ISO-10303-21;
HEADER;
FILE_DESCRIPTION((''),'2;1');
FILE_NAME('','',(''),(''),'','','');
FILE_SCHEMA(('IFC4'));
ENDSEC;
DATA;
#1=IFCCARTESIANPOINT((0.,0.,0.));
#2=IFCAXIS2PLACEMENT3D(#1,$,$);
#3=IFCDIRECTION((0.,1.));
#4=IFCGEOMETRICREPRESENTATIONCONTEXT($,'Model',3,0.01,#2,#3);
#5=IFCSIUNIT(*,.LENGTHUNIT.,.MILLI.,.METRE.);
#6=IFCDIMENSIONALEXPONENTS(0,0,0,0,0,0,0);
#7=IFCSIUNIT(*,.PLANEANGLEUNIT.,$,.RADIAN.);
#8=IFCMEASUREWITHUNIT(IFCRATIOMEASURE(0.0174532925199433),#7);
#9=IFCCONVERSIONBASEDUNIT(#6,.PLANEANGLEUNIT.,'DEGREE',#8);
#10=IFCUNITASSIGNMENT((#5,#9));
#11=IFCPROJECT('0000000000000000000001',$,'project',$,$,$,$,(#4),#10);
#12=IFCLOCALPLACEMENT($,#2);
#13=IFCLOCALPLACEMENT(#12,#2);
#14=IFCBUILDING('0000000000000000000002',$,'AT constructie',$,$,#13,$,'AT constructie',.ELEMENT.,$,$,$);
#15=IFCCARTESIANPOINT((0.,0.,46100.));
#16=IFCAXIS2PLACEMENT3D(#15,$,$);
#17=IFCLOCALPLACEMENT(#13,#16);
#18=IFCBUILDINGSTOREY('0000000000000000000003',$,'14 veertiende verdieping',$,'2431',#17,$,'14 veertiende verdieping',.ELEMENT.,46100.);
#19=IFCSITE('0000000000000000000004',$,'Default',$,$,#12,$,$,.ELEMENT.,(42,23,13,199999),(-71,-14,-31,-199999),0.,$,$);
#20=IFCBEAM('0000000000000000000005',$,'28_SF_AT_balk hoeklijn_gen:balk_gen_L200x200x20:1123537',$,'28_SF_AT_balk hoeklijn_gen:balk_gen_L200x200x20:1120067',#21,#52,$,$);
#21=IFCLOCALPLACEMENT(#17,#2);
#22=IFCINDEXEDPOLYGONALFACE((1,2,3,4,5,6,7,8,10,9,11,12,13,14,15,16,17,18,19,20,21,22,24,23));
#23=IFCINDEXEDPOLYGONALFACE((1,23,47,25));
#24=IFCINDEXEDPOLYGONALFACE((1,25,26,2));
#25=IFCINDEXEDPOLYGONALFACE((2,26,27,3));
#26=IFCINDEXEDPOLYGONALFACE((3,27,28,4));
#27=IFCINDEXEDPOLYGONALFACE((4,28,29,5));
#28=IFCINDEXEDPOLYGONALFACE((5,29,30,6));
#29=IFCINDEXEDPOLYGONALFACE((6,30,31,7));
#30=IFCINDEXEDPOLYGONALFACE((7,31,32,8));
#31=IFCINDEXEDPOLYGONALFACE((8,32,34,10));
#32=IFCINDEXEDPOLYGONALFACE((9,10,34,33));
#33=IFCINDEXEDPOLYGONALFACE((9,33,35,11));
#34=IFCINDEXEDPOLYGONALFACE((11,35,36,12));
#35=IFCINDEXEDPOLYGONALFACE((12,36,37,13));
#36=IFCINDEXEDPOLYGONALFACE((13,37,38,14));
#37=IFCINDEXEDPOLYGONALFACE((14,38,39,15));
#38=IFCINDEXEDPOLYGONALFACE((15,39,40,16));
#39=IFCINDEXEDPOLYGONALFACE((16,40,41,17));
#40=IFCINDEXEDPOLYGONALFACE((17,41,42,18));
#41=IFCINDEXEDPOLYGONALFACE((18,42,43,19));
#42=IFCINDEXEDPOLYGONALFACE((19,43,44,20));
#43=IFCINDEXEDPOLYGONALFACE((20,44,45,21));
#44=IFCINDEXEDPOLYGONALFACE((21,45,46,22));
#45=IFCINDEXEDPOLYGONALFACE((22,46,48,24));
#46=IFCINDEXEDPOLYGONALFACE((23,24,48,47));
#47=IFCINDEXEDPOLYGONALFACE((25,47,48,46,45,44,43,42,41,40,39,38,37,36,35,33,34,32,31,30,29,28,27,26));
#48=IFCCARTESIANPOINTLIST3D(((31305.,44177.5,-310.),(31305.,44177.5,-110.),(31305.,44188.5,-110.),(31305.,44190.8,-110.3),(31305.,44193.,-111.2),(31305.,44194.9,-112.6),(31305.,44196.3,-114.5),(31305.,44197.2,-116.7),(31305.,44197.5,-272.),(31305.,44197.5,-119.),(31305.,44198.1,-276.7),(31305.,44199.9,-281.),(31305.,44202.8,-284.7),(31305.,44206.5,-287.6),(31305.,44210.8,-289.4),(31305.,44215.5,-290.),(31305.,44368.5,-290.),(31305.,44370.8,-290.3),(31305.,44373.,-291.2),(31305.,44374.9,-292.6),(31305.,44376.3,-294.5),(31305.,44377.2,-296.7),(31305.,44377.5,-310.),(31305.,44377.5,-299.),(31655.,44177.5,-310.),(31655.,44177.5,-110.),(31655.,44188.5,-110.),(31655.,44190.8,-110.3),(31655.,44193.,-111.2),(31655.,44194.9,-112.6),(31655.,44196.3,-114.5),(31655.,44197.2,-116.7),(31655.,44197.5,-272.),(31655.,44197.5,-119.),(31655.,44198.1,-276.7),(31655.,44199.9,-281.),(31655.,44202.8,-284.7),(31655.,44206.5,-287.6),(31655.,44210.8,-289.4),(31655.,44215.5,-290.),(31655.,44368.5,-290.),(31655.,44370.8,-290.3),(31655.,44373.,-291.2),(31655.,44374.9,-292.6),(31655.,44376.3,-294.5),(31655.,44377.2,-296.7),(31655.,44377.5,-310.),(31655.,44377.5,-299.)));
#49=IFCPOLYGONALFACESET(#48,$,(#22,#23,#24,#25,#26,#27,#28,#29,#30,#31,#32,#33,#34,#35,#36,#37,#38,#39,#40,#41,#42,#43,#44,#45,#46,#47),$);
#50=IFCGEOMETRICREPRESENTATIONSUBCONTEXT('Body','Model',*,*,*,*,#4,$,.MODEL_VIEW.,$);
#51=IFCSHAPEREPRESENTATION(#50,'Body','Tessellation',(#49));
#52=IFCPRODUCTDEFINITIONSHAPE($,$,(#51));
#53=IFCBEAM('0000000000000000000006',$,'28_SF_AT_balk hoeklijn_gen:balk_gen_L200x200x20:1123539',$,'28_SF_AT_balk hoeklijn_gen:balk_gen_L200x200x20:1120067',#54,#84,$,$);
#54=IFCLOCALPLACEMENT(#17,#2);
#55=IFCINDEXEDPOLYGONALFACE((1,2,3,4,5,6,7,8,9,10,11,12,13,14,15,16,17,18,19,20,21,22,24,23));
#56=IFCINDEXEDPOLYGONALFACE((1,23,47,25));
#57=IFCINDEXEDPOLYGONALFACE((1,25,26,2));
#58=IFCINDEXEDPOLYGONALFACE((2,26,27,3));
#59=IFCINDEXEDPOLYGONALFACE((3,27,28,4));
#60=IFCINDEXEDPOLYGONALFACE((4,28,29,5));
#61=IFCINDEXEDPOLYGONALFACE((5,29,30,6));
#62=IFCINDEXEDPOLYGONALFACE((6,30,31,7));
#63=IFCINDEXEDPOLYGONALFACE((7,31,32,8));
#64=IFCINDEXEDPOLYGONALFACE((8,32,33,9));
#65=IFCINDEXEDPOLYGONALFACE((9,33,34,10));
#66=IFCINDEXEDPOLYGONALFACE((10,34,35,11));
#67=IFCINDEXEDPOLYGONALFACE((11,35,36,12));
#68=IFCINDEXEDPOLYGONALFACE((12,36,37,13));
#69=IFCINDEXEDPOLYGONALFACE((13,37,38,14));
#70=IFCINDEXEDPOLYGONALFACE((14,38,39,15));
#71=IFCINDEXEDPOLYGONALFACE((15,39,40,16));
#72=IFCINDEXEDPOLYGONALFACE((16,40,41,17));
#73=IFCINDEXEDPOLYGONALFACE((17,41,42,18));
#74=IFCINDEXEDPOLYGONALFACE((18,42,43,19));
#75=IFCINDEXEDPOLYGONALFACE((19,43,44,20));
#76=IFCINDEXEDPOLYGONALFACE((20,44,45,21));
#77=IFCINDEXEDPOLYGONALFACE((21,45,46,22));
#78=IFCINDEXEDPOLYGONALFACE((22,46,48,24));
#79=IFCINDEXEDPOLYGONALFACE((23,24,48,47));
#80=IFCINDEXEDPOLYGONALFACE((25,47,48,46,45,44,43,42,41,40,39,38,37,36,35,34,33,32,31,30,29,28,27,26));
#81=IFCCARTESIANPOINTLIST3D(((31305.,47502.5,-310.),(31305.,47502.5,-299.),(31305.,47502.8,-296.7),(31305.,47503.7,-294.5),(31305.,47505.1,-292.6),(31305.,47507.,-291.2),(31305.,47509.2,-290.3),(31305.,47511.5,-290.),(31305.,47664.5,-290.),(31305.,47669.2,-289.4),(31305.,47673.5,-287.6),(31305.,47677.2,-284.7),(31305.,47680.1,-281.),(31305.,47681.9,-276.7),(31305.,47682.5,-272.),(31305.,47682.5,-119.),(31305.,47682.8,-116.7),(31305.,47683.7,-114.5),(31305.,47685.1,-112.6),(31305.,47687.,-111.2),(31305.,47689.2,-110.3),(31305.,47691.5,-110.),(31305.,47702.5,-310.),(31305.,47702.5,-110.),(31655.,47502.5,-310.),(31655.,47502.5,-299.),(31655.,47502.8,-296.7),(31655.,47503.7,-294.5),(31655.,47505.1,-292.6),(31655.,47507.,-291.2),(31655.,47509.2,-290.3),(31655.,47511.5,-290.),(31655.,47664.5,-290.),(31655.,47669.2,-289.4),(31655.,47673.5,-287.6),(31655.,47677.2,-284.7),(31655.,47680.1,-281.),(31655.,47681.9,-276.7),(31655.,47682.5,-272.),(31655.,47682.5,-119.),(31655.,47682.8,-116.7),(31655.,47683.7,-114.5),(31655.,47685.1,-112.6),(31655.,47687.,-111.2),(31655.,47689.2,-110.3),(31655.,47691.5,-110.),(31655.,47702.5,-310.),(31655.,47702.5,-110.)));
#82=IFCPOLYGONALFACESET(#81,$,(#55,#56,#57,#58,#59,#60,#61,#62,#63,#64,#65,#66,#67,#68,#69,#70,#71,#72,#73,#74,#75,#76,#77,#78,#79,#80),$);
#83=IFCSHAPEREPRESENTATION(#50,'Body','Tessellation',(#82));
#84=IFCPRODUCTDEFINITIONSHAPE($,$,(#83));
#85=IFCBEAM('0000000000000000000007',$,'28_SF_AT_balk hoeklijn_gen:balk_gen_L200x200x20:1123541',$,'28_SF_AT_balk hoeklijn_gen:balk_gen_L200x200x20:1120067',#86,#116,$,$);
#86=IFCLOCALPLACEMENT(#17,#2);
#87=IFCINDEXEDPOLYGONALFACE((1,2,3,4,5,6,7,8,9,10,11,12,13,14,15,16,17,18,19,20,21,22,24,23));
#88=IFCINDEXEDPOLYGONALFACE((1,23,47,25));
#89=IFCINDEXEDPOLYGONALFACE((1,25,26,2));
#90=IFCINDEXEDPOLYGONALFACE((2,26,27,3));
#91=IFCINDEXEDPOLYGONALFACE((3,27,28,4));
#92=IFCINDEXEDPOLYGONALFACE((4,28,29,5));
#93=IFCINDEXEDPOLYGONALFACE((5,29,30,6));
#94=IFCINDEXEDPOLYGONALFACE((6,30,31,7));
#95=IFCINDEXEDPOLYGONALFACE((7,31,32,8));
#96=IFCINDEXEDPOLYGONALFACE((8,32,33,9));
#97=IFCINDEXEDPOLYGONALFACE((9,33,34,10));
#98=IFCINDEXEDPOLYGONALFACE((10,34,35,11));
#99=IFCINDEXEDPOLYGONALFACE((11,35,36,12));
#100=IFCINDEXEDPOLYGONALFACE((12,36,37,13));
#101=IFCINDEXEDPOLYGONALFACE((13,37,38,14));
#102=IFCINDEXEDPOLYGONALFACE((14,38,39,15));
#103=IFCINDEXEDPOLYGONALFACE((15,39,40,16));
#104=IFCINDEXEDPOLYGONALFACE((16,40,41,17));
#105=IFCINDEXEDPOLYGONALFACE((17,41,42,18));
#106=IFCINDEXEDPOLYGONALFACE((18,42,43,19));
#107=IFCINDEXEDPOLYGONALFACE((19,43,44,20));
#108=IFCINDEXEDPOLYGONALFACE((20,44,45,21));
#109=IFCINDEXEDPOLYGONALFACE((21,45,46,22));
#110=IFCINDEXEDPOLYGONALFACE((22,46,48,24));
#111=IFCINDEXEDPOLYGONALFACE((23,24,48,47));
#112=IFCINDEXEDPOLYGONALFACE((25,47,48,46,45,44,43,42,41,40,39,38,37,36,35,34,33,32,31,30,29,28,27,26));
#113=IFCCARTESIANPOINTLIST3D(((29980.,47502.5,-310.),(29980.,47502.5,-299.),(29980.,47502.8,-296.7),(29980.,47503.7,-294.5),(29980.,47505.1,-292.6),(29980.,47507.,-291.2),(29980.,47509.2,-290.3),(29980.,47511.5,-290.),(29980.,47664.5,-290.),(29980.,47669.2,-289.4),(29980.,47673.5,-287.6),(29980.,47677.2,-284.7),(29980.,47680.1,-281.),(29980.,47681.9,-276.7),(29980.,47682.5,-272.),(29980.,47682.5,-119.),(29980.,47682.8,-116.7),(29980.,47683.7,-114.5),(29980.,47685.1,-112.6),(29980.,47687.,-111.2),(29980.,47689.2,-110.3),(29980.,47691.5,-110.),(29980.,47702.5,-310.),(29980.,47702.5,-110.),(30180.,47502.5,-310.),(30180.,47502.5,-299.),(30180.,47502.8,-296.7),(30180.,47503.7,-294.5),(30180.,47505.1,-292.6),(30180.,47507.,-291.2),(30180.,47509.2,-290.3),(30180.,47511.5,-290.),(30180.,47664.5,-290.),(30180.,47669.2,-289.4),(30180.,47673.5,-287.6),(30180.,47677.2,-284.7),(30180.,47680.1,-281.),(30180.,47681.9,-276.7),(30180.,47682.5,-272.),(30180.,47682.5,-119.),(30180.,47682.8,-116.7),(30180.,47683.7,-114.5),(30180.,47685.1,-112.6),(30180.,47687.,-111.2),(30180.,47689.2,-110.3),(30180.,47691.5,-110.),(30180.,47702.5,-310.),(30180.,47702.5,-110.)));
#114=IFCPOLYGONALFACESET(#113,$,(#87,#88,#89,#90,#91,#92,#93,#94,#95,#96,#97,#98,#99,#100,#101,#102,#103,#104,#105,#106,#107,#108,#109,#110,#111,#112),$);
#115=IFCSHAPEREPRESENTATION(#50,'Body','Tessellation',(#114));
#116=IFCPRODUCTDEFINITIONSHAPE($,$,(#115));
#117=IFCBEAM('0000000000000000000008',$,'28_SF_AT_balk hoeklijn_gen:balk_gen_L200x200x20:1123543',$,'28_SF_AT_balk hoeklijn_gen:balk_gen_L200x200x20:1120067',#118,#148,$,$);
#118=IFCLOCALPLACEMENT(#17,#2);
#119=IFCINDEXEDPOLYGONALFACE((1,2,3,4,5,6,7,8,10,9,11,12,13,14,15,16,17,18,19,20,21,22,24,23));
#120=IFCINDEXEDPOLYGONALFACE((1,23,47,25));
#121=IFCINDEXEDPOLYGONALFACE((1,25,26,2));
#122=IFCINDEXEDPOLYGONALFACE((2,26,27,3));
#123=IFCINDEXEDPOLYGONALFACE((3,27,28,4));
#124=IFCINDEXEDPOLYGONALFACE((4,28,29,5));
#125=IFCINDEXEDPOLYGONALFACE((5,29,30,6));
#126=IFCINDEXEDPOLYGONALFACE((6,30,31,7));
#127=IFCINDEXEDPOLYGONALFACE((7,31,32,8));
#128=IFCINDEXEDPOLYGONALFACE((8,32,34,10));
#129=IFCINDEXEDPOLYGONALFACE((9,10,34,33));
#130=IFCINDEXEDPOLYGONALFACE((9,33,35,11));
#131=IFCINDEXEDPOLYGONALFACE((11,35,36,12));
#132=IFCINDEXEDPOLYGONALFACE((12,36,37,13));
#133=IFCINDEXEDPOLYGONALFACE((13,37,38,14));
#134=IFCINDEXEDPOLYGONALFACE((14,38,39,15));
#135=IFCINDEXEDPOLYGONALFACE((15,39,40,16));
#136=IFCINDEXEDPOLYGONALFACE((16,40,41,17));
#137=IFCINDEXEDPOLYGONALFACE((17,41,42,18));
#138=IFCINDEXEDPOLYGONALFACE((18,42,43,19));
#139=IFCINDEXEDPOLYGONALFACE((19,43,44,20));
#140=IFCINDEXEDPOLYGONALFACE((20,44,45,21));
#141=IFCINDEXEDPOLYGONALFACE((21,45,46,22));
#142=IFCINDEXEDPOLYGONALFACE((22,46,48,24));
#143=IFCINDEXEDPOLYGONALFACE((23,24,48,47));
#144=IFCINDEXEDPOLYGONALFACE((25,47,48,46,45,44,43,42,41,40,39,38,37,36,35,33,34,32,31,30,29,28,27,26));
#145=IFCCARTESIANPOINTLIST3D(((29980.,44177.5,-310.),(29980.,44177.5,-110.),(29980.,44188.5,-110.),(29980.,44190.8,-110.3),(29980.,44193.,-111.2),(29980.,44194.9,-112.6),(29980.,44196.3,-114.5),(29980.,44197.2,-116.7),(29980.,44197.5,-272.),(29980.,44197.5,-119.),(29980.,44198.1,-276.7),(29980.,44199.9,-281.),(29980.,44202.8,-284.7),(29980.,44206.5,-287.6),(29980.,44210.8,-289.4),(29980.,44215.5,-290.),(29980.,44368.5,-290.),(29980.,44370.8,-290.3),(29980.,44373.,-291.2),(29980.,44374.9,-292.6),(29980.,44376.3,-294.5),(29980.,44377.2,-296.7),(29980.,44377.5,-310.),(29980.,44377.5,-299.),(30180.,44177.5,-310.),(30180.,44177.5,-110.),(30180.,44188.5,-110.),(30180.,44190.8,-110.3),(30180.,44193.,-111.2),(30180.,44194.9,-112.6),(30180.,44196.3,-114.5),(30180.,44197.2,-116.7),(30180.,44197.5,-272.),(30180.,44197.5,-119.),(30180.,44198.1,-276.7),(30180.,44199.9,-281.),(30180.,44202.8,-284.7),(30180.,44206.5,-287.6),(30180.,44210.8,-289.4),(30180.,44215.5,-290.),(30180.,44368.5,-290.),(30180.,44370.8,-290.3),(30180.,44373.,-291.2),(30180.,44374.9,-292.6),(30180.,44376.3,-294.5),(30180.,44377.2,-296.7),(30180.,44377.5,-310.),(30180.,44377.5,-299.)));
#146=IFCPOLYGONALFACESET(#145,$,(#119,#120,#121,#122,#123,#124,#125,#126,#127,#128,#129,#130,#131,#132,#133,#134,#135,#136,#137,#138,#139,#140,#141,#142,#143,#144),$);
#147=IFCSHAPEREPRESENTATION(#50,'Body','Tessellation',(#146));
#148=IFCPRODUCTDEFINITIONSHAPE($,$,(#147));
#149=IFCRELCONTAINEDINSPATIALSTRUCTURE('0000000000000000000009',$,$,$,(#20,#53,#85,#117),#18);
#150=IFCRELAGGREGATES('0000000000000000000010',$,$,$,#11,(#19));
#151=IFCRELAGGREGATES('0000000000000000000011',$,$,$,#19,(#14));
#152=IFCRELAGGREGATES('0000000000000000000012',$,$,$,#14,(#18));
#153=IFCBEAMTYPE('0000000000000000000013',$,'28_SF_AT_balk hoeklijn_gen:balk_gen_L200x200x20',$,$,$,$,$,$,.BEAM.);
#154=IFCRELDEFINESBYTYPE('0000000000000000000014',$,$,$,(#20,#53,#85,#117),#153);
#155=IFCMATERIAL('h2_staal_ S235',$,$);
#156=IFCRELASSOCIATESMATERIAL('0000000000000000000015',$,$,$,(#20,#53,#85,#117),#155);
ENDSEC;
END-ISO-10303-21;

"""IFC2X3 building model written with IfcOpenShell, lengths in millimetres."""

from ifc_helpers import new_model, entity, si_unit, converted_unit, direction, frame, frame_2d, origin, place, context, subcontext, project, spatial, polyline, circle_curve, parameter, trimmed, segment, composite_curve, outline, extrude, material, type_object, element, save


model = new_model("IFC2X3")

# Units and contexts
model_context = context("Model", 3, precision=0.01, world=origin(), true_north=direction((0.0, 1.0)))
body_context = subcontext(model_context, "Body", "Model", "MODEL_VIEW")
ifc_project = project(units=[si_unit("LENGTHUNIT", "METRE", prefix="MILLI"), converted_unit("PLANEANGLEUNIT", "DEGREE", entity("IfcRatioMeasure", 0.0174532925199433), si_unit("PLANEANGLEUNIT", "RADIAN"), dimensions=[0, 0, 0, 0, 0, 0, 0])], contexts=[model_context])

# Site, building, storey
site_placement = place(None, origin())
site = spatial("IfcSite", under=ifc_project, at=site_placement, Name="Default", CompositionType="ELEMENT", RefLatitude=(42, 23, 13, 199999), RefLongitude=(-71, -14, -31, -199999), RefElevation=0.0)
building_placement = place(site_placement, origin())
building = spatial("IfcBuilding", under=site, at=building_placement, Name="AT constructie", LongName="AT constructie", CompositionType="ELEMENT")
storey_placement = place(building_placement, frame((0.0, 0.0, 46100.0)))
storey = spatial("IfcBuildingStorey", under=building, at=storey_placement, Name="14 veertiende verdieping", ObjectType="2431", LongName="14 veertiende verdieping", CompositionType="ELEMENT", Elevation=46100.0)

# Beams
ifc_material_1 = material(Name="h2_staal_ S235")
beam_type = type_object("IfcBeamType", Name="28_SF_AT_balk hoeklijn_gen:balk_gen_L200x200x20", PredefinedType="BEAM")
beam_1_placement = place(storey_placement, frame((31305.0, 44177.5, -70.0)))
element("IfcBeam", 1, at=beam_1_placement, inside=storey, type_object=beam_type, material=ifc_material_1, Name="28_SF_AT_balk hoeklijn_gen:balk_gen_L200x200x20:1123537", ObjectType="28_SF_AT_balk hoeklijn_gen:balk_gen_L200x200x20:1120067", context=body_context, shape_type="SweptSolid", body=[
    extrude(outline(composite_curve([segment(polyline([(-124.4, -75.6), (75.6, -75.6)]), True, "CONTINUOUS"), segment(polyline([(75.6, -75.6), (75.6, 124.4)]), True, "CONTINUOUS"), segment(polyline([(75.6, 124.4), (64.6, 124.4)]), True, "CONTINUOUS"), segment(trimmed(circle_curve(frame_2d((64.6, 115.4), x_axis=(0.0, 1.0)), 9.0), [parameter(0.0)], [parameter(90.0)], True, "PARAMETER"), True, "CONTINUOUS"), segment(polyline([(55.6, 115.4), (55.6, -37.6)]), True, "CONTINUOUS"), segment(trimmed(circle_curve(frame_2d((37.6, -37.6), x_axis=(1.0, 0.0)), 18.0), [parameter(270.0)], [parameter(0.0)], True, "PARAMETER"), False, "CONTINUOUS"), segment(polyline([(37.6, -55.6), (-115.4, -55.6)]), True, "CONTINUOUS"), segment(trimmed(circle_curve(frame_2d((-115.4, -64.6), x_axis=(0.0, 1.0)), 9.0), [parameter(0.0)], [parameter(90.0)], True, "PARAMETER"), True, "CONTINUOUS"), segment(polyline([(-124.4, -64.6), (-124.4, -75.6)]), True, "CONTINUOUS")], self_intersect=False)), frame((0.0, 75.6, -164.4), z_axis=(1.0, 0.0, 0.0), x_axis=(0.0, 0.0, -1.0)), (0.0, 0.0, 1.0), 350.0),
])
beam_2_placement = place(storey_placement, frame((31655.0, 47702.5, -70.0), z_axis=(0.0, 0.0, 1.0), x_axis=(-1.0, 0.0, 0.0)))
element("IfcBeam", 2, at=beam_2_placement, inside=storey, type_object=beam_type, material=ifc_material_1, Name="28_SF_AT_balk hoeklijn_gen:balk_gen_L200x200x20:1123539", ObjectType="28_SF_AT_balk hoeklijn_gen:balk_gen_L200x200x20:1120067", context=body_context, shape_type="SweptSolid", body=[
    extrude(outline(composite_curve([segment(polyline([(-124.4, -75.6), (75.6, -75.6)]), True, "CONTINUOUS"), segment(polyline([(75.6, -75.6), (75.6, 124.4)]), True, "CONTINUOUS"), segment(polyline([(75.6, 124.4), (64.6, 124.4)]), True, "CONTINUOUS"), segment(trimmed(circle_curve(frame_2d((64.6, 115.4), x_axis=(0.0, 1.0)), 9.0), [parameter(0.0)], [parameter(90.0)], True, "PARAMETER"), True, "CONTINUOUS"), segment(polyline([(55.6, 115.4), (55.6, -37.6)]), True, "CONTINUOUS"), segment(trimmed(circle_curve(frame_2d((37.6, -37.6), x_axis=(1.0, 0.0)), 18.0), [parameter(270.0)], [parameter(0.0)], True, "PARAMETER"), False, "CONTINUOUS"), segment(polyline([(37.6, -55.6), (-115.4, -55.6)]), True, "CONTINUOUS"), segment(trimmed(circle_curve(frame_2d((-115.4, -64.6), x_axis=(0.0, 1.0)), 9.0), [parameter(0.0)], [parameter(90.0)], True, "PARAMETER"), True, "CONTINUOUS"), segment(polyline([(-124.4, -64.6), (-124.4, -75.6)]), True, "CONTINUOUS")], self_intersect=False)), frame((0.0, 75.6, -164.4), z_axis=(1.0, 0.0, 0.0), x_axis=(0.0, 0.0, -1.0)), (0.0, 0.0, 1.0), 350.0),
])
beam_3_placement = place(storey_placement, frame((30180.0, 47702.5, -70.0), z_axis=(0.0, 0.0, 1.0), x_axis=(-1.0, 0.0, 0.0)))
element("IfcBeam", 3, at=beam_3_placement, inside=storey, type_object=beam_type, material=ifc_material_1, Name="28_SF_AT_balk hoeklijn_gen:balk_gen_L200x200x20:1123541", ObjectType="28_SF_AT_balk hoeklijn_gen:balk_gen_L200x200x20:1120067", context=body_context, shape_type="SweptSolid", body=[
    extrude(outline(composite_curve([segment(polyline([(-124.4, -75.6), (75.6, -75.6)]), True, "CONTINUOUS"), segment(polyline([(75.6, -75.6), (75.6, 124.4)]), True, "CONTINUOUS"), segment(polyline([(75.6, 124.4), (64.6, 124.4)]), True, "CONTINUOUS"), segment(trimmed(circle_curve(frame_2d((64.6, 115.4), x_axis=(0.0, 1.0)), 9.0), [parameter(0.0)], [parameter(90.0)], True, "PARAMETER"), True, "CONTINUOUS"), segment(polyline([(55.6, 115.4), (55.6, -37.6)]), True, "CONTINUOUS"), segment(trimmed(circle_curve(frame_2d((37.6, -37.6), x_axis=(1.0, 0.0)), 18.0), [parameter(270.0)], [parameter(0.0)], True, "PARAMETER"), False, "CONTINUOUS"), segment(polyline([(37.6, -55.6), (-115.4, -55.6)]), True, "CONTINUOUS"), segment(trimmed(circle_curve(frame_2d((-115.4, -64.6), x_axis=(0.0, 1.0)), 9.0), [parameter(0.0)], [parameter(90.0)], True, "PARAMETER"), True, "CONTINUOUS"), segment(polyline([(-124.4, -64.6), (-124.4, -75.6)]), True, "CONTINUOUS")], self_intersect=False)), frame((0.0, 75.6, -164.4), z_axis=(1.0, 0.0, 0.0), x_axis=(0.0, 0.0, -1.0)), (0.0, 0.0, 1.0), 200.0),
])
beam_4_placement = place(storey_placement, frame((29980.0, 44177.5, -70.0)))
element("IfcBeam", 4, at=beam_4_placement, inside=storey, type_object=beam_type, material=ifc_material_1, Name="28_SF_AT_balk hoeklijn_gen:balk_gen_L200x200x20:1123543", ObjectType="28_SF_AT_balk hoeklijn_gen:balk_gen_L200x200x20:1120067", context=body_context, shape_type="SweptSolid", body=[
    extrude(outline(composite_curve([segment(polyline([(-124.4, -75.6), (75.6, -75.6)]), True, "CONTINUOUS"), segment(polyline([(75.6, -75.6), (75.6, 124.4)]), True, "CONTINUOUS"), segment(polyline([(75.6, 124.4), (64.6, 124.4)]), True, "CONTINUOUS"), segment(trimmed(circle_curve(frame_2d((64.6, 115.4), x_axis=(0.0, 1.0)), 9.0), [parameter(0.0)], [parameter(90.0)], True, "PARAMETER"), True, "CONTINUOUS"), segment(polyline([(55.6, 115.4), (55.6, -37.6)]), True, "CONTINUOUS"), segment(trimmed(circle_curve(frame_2d((37.6, -37.6), x_axis=(1.0, 0.0)), 18.0), [parameter(270.0)], [parameter(0.0)], True, "PARAMETER"), False, "CONTINUOUS"), segment(polyline([(37.6, -55.6), (-115.4, -55.6)]), True, "CONTINUOUS"), segment(trimmed(circle_curve(frame_2d((-115.4, -64.6), x_axis=(0.0, 1.0)), 9.0), [parameter(0.0)], [parameter(90.0)], True, "PARAMETER"), True, "CONTINUOUS"), segment(polyline([(-124.4, -64.6), (-124.4, -75.6)]), True, "CONTINUOUS")], self_intersect=False)), frame((0.0, 75.6, -164.4), z_axis=(1.0, 0.0, 0.0), x_axis=(0.0, 0.0, -1.0)), (0.0, 0.0, 1.0), 200.0),
])

save(model, "model.ifc")
